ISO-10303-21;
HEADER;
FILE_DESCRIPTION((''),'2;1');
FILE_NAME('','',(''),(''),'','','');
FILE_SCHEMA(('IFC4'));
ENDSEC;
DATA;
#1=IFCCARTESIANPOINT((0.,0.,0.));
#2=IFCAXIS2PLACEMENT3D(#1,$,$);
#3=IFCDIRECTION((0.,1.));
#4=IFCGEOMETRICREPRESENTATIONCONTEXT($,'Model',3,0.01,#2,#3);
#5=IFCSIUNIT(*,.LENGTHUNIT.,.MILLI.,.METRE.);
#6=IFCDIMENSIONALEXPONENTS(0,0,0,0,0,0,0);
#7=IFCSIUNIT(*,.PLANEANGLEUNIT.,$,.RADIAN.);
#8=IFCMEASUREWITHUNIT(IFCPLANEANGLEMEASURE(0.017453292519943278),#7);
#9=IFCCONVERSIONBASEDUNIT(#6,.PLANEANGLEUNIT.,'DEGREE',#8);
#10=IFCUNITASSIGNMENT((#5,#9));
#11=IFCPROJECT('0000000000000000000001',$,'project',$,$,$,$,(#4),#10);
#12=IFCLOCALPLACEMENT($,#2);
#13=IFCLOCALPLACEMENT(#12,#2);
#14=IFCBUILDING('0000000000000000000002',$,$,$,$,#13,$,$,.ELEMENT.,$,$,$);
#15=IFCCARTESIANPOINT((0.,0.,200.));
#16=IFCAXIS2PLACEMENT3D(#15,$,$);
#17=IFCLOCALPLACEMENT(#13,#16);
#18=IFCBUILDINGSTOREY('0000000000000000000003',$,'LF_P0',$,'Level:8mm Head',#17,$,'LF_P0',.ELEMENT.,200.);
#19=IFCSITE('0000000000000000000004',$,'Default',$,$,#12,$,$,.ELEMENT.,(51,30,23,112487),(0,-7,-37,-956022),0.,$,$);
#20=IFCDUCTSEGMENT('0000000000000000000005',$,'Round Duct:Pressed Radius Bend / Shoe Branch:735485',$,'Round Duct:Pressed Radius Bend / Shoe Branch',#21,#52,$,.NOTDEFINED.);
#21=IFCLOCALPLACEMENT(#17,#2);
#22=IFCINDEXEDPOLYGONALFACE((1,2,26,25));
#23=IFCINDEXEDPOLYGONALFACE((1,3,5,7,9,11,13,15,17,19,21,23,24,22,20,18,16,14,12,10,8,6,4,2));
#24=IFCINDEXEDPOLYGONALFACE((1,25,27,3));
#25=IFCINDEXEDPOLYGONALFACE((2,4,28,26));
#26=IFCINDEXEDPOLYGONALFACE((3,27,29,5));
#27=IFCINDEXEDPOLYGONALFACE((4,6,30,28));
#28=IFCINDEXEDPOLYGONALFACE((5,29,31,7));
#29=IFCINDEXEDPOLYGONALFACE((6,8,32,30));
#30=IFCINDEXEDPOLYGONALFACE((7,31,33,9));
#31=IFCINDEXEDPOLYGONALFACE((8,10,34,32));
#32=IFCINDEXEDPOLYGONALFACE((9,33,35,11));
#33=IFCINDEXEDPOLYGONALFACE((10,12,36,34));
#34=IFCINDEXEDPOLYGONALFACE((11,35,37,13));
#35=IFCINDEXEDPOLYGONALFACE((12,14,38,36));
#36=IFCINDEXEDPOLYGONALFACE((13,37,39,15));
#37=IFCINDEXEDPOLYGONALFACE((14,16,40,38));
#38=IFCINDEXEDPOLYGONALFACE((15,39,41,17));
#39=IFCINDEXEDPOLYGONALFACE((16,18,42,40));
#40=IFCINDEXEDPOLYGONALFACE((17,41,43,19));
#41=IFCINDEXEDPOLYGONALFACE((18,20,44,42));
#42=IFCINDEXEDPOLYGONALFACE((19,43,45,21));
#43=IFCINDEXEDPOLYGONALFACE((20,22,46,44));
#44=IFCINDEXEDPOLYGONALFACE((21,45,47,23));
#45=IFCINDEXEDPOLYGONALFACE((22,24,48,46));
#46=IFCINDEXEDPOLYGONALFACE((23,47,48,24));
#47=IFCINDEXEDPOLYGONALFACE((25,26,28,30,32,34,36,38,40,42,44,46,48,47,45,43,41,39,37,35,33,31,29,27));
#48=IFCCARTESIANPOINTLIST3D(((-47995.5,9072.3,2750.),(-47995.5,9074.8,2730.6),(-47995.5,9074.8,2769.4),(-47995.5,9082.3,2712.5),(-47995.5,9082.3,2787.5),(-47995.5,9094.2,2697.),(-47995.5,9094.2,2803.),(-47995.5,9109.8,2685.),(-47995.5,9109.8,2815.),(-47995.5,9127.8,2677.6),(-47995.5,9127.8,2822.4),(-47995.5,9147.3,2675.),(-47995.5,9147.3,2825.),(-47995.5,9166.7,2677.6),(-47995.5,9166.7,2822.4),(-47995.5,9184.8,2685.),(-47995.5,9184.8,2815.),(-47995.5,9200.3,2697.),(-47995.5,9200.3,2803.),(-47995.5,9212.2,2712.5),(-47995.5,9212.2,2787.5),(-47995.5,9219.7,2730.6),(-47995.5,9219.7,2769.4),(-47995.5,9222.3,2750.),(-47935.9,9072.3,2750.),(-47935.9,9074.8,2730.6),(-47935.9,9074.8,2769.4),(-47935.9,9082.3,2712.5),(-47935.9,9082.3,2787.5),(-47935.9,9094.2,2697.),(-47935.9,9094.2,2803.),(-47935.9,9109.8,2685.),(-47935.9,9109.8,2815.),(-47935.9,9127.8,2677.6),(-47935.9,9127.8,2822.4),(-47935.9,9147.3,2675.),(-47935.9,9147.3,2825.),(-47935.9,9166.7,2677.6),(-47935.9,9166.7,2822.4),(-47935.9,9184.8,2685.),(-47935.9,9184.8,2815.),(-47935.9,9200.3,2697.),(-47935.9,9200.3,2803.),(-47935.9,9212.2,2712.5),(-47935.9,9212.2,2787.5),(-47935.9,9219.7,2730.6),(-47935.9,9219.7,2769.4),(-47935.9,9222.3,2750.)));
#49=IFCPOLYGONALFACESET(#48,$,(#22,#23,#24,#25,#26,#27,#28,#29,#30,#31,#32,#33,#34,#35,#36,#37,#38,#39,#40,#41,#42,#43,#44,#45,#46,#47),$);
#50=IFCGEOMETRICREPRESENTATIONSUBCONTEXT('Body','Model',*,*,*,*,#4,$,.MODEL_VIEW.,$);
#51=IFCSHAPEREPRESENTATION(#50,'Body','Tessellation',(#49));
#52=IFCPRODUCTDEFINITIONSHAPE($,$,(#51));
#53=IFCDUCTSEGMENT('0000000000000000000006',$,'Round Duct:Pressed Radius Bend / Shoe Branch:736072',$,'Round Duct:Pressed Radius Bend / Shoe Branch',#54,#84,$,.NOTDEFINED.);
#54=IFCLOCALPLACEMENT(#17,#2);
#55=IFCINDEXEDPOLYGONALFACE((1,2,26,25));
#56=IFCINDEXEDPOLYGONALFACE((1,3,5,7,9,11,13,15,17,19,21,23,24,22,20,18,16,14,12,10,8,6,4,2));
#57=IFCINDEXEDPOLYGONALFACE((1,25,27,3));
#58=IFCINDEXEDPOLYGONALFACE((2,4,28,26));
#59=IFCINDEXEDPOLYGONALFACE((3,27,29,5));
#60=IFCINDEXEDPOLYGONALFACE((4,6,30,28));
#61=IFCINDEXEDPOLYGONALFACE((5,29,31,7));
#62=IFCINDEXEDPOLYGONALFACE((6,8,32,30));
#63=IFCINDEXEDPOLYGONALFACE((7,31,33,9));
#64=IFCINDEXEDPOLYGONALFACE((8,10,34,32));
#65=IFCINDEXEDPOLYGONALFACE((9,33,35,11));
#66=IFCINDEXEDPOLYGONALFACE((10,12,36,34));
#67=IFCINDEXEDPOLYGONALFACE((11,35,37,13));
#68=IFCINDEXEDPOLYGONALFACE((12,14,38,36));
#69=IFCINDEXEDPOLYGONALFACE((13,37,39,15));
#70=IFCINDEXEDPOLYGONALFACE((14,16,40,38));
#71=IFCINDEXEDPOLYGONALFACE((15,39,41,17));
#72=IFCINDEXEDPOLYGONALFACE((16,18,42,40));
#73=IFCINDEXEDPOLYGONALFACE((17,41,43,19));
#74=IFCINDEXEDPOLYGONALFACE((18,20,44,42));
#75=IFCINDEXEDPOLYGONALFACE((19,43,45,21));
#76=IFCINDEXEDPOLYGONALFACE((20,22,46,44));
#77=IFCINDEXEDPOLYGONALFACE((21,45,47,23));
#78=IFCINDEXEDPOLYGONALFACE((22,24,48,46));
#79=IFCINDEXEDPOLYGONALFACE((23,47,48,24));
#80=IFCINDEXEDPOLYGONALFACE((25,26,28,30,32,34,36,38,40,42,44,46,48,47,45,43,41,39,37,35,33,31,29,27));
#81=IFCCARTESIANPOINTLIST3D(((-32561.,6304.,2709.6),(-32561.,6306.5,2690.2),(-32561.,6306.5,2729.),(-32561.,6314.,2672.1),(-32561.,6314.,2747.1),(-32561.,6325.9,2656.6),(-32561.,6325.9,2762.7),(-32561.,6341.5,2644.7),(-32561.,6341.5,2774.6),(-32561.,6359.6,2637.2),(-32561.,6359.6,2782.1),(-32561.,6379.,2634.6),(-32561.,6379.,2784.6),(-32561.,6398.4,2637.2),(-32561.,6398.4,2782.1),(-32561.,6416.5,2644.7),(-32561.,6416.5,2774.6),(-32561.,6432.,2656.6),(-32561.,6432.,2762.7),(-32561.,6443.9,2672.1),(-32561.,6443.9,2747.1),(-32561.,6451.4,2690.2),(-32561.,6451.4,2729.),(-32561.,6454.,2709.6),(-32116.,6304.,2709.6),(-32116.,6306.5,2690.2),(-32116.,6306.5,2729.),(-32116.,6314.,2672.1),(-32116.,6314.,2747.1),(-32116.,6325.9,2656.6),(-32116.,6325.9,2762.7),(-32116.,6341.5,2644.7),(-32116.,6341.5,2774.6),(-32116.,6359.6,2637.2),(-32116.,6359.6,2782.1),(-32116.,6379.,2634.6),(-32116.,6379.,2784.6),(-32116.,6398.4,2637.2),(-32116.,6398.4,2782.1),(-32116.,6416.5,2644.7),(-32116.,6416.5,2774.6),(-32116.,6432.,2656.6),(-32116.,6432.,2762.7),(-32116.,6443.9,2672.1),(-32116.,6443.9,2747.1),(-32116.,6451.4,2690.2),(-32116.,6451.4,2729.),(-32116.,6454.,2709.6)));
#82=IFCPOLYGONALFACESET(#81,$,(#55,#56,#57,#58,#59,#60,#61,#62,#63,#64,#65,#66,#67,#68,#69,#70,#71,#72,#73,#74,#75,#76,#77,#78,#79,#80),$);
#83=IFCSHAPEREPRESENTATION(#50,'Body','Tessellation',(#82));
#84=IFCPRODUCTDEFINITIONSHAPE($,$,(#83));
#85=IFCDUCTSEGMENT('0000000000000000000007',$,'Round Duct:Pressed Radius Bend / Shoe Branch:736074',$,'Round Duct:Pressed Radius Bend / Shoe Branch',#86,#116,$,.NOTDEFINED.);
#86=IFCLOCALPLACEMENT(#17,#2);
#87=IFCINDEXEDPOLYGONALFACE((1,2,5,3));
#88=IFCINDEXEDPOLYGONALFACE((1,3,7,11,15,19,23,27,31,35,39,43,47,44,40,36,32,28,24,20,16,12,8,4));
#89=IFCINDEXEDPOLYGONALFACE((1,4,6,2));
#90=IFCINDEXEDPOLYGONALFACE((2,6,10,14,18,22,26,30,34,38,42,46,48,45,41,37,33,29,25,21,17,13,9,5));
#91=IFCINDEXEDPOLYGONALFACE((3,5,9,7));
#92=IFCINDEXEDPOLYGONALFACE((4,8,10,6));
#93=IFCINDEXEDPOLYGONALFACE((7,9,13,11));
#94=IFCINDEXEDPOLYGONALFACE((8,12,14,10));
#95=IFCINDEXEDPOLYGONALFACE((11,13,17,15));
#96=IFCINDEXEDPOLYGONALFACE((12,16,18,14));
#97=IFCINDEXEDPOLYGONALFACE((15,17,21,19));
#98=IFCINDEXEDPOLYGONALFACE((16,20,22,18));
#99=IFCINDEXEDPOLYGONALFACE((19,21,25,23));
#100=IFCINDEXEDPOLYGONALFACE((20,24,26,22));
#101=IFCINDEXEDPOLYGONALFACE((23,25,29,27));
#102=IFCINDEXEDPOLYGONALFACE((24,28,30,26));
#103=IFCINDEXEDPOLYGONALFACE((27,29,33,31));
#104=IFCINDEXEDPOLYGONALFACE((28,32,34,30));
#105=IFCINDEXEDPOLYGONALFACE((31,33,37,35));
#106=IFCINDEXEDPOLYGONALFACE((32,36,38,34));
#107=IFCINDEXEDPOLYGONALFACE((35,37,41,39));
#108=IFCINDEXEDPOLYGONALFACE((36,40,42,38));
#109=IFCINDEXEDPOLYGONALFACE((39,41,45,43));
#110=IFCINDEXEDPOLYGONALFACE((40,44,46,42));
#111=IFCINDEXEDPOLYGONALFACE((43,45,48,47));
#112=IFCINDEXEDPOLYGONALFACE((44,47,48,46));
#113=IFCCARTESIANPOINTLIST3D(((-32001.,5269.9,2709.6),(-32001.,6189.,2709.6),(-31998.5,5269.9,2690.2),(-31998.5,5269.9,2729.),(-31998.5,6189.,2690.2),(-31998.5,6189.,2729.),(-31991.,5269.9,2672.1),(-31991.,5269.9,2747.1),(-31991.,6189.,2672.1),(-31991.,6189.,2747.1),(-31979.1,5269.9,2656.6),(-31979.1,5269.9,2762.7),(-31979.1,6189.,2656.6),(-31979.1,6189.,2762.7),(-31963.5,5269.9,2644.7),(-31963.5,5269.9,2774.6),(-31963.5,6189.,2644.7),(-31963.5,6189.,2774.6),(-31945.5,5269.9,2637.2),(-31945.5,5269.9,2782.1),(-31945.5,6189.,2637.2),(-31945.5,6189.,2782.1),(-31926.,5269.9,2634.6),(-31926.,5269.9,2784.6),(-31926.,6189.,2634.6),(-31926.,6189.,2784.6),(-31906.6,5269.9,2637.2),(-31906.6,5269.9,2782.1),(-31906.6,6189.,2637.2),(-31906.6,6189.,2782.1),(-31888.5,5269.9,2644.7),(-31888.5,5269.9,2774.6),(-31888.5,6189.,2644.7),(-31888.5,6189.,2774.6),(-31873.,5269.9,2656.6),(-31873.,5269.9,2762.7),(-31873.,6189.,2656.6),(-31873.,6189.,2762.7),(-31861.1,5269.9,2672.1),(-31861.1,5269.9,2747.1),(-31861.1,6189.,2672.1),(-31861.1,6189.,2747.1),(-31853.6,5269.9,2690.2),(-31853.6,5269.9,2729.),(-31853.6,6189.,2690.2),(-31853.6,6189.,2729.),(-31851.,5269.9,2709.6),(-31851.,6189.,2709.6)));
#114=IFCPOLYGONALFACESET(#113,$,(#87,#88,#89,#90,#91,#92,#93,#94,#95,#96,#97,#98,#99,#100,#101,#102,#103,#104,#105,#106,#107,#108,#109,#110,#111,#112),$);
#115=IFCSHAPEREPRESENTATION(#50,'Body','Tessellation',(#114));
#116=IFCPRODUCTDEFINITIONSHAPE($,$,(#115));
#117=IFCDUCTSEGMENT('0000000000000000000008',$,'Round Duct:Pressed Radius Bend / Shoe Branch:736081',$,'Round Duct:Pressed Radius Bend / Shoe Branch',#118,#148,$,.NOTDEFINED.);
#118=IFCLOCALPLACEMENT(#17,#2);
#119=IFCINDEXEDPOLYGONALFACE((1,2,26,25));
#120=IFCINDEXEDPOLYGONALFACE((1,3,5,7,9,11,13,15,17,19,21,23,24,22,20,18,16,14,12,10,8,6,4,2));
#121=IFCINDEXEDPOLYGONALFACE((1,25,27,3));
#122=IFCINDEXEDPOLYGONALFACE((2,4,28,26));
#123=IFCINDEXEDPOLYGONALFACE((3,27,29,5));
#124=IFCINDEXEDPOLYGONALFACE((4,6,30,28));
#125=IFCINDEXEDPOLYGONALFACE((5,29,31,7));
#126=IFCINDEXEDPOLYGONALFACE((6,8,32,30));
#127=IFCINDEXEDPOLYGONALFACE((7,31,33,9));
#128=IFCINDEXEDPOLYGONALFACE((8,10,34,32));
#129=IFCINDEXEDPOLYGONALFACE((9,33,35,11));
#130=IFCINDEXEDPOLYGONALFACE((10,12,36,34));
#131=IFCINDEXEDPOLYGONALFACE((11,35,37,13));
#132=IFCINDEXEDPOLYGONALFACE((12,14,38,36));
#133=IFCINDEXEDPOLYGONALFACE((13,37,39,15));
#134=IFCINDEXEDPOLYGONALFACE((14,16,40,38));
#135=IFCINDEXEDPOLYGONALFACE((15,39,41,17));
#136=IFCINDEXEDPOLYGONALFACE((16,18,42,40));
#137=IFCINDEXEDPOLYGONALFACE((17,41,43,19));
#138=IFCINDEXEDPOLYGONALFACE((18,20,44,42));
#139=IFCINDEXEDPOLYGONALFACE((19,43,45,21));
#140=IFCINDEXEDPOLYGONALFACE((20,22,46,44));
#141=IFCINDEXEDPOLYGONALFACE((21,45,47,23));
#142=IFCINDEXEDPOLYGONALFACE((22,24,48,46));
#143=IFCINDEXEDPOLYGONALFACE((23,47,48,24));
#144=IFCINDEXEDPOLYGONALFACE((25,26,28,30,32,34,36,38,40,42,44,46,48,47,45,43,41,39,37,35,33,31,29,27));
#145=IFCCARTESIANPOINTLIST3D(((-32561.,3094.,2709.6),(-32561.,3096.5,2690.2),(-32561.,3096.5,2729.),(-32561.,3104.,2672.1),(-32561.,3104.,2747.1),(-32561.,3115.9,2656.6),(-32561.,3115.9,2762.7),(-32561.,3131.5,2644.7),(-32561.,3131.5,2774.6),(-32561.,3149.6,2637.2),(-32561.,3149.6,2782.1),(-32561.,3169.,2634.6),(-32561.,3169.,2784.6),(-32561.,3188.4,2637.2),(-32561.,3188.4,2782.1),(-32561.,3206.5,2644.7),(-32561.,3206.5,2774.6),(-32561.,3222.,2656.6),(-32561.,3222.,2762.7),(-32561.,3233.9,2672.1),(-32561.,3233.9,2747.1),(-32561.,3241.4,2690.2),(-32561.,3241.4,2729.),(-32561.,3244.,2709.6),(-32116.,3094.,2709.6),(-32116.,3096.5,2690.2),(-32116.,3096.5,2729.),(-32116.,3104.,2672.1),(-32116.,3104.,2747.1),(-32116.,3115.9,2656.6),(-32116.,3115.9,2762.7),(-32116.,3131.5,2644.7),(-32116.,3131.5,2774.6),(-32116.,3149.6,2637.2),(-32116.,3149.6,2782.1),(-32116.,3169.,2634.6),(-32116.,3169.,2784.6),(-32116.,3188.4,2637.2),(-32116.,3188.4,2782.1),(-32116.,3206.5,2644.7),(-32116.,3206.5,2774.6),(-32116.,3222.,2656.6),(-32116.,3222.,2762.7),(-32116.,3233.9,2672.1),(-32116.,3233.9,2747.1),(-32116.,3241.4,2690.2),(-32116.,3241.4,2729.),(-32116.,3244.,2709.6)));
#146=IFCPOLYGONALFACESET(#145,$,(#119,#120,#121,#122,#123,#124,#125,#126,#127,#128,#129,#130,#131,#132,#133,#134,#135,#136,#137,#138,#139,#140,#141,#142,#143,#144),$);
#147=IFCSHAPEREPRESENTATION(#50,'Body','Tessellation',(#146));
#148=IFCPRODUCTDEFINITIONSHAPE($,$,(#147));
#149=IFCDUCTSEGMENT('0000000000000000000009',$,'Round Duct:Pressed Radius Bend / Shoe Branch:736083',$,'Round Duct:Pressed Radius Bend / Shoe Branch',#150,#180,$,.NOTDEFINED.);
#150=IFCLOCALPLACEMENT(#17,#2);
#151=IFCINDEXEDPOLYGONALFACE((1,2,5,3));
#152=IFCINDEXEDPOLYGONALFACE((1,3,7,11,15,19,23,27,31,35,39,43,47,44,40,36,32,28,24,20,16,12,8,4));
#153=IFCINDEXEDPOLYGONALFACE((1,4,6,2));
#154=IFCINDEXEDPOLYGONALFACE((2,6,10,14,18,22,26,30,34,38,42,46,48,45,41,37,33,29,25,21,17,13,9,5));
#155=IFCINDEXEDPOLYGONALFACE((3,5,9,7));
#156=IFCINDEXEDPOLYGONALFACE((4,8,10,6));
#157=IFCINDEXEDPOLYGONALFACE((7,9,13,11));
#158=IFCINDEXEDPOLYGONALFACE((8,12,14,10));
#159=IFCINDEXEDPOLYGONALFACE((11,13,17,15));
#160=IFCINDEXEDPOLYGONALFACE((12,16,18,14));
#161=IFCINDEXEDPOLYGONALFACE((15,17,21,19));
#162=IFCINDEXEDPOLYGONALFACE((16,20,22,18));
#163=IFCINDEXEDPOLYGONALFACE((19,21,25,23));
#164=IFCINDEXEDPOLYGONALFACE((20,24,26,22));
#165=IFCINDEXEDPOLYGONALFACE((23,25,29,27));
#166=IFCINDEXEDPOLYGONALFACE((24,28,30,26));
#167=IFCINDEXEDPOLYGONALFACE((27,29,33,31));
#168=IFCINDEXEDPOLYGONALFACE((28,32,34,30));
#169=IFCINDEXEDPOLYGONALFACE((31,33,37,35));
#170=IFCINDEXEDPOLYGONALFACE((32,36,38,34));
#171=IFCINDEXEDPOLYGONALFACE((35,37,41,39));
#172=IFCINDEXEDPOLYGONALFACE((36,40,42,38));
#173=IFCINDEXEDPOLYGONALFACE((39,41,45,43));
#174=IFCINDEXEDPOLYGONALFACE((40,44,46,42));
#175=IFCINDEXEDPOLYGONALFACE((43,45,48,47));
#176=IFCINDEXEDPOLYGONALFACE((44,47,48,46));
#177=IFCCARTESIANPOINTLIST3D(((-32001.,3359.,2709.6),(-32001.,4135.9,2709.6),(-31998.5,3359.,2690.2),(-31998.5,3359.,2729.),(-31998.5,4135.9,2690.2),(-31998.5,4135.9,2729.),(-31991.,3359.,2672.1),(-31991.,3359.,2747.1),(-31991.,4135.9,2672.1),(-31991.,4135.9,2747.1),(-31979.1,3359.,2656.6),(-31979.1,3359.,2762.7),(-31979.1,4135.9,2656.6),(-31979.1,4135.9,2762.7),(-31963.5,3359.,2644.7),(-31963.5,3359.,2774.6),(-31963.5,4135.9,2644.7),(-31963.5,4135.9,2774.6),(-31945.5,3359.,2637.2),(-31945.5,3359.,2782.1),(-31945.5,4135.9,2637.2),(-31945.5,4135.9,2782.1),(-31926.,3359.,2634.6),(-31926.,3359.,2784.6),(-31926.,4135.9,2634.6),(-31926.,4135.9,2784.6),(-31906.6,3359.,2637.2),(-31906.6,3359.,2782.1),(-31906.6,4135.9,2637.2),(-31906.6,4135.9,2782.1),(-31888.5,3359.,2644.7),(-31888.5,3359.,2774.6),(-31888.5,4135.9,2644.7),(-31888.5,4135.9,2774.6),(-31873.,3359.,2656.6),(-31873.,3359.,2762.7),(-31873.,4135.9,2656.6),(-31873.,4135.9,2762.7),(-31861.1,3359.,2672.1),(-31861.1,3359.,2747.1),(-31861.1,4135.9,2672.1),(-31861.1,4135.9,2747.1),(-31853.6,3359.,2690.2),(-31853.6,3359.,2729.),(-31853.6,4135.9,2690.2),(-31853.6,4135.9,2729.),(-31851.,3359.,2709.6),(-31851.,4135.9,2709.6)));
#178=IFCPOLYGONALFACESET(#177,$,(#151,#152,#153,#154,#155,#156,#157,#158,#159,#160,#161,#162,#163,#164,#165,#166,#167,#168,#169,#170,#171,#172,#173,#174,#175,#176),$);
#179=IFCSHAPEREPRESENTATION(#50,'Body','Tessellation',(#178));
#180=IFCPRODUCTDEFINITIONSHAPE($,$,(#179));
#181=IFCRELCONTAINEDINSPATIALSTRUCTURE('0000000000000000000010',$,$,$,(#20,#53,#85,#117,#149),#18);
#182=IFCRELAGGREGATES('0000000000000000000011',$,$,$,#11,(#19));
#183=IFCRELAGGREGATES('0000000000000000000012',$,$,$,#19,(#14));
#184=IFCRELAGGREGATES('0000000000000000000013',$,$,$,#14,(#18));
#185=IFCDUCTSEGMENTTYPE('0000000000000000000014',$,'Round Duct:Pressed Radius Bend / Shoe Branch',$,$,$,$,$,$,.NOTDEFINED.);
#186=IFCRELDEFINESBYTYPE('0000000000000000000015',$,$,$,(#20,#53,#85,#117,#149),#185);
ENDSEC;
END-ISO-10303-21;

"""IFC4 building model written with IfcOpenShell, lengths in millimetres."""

from ifc_helpers import new_model, entity, si_unit, converted_unit, direction, frame, origin, place, context, subcontext, project, spatial, arc, indexed_curve, outline, extrude, type_object, element, save


model = new_model("IFC4")

# Units and contexts
model_context = context("Model", 3, precision=0.01, world=origin(), true_north=direction((0.0, 1.0)))
body_context = subcontext(model_context, "Body", "Model", "MODEL_VIEW")
ifc_project = project(units=[si_unit("LENGTHUNIT", "METRE", prefix="MILLI"), converted_unit("PLANEANGLEUNIT", "DEGREE", entity("IfcPlaneAngleMeasure", 0.017453292519943278), si_unit("PLANEANGLEUNIT", "RADIAN"), dimensions=[0, 0, 0, 0, 0, 0, 0])], contexts=[model_context])

# Site, building, storey
site_placement = place(None, origin())
site = spatial("IfcSite", under=ifc_project, at=site_placement, Name="Default", CompositionType="ELEMENT", RefLatitude=(51, 30, 23, 112487), RefLongitude=(0, -7, -37, -956022), RefElevation=0.0)
building_placement = place(site_placement, origin())
building = spatial("IfcBuilding", under=site, at=building_placement, CompositionType="ELEMENT")
storey_placement = place(building_placement, frame((0.0, 0.0, 200.0)))
storey = spatial("IfcBuildingStorey", under=building, at=storey_placement, Name="LF_P0", ObjectType="Level:8mm Head", LongName="LF_P0", CompositionType="ELEMENT", Elevation=200.0)

# Duct segments
duct_segment_type_1 = type_object("IfcDuctSegmentType", Name="Round Duct:Pressed Radius Bend / Shoe Branch", PredefinedType="NOTDEFINED")
duct_segment_1_placement = place(storey_placement, origin())
element("IfcDuctSegment", 1, at=duct_segment_1_placement, inside=storey, type_object=duct_segment_type_1, Name="Round Duct:Pressed Radius Bend / Shoe Branch:735485", ObjectType="Round Duct:Pressed Radius Bend / Shoe Branch", PredefinedType="NOTDEFINED", context=body_context, shape_type="SweptSolid", body=[
    extrude(outline(indexed_curve([(75.0, 0.0), (53.0, 53.0), (0.0, 75.0), (-53.0, 53.0), (-75.0, 0.0), (-53.0, -53.0), (0.0, -75.0), (53.0, -53.0)], segments=[arc(1, 2, 3), arc(3, 4, 5), arc(5, 6, 7), arc(7, 8, 1)], self_intersect=False)), frame((-47995.5, 9147.3, 2750.0), z_axis=(1.0, 0.0, 0.0), x_axis=(0.0, -1.0, 0.0)), (0.0, 0.0, 1.0), 59.6),
])
duct_segment_2_placement = place(storey_placement, origin())
element("IfcDuctSegment", 2, at=duct_segment_2_placement, inside=storey, type_object=duct_segment_type_1, Name="Round Duct:Pressed Radius Bend / Shoe Branch:736072", ObjectType="Round Duct:Pressed Radius Bend / Shoe Branch", PredefinedType="NOTDEFINED", context=body_context, shape_type="SweptSolid", body=[
    extrude(outline(indexed_curve([(75.0, 0.0), (53.0, 53.0), (0.0, 75.0), (-53.0, 53.0), (-75.0, 0.0), (-53.0, -53.0), (0.0, -75.0), (53.0, -53.0)], segments=[arc(1, 2, 3), arc(3, 4, 5), arc(5, 6, 7), arc(7, 8, 1)], self_intersect=False)), frame((-32561.0, 6379.0, 2709.6), z_axis=(1.0, 0.0, 0.0), x_axis=(0.0, -1.0, 0.0)), (0.0, 0.0, 1.0), 445.0),
])
duct_segment_3_placement = place(storey_placement, origin())
element("IfcDuctSegment", 3, at=duct_segment_3_placement, inside=storey, type_object=duct_segment_type_1, Name="Round Duct:Pressed Radius Bend / Shoe Branch:736074", ObjectType="Round Duct:Pressed Radius Bend / Shoe Branch", PredefinedType="NOTDEFINED", context=body_context, shape_type="SweptSolid", body=[
    extrude(outline(indexed_curve([(75.0, 0.0), (53.0, 53.0), (0.0, 75.0), (-53.0, 53.0), (-75.0, 0.0), (-53.0, -53.0), (0.0, -75.0), (53.0, -53.0)], segments=[arc(1, 2, 3), arc(3, 4, 5), arc(5, 6, 7), arc(7, 8, 1)], self_intersect=False)), frame((-31926.0, 5269.9, 2709.6), z_axis=(0.0, 1.0, 0.0), x_axis=(1.0, 0.0, 0.0)), (0.0, 0.0, 1.0), 919.0),
])
duct_segment_4_placement = place(storey_placement, origin())
element("IfcDuctSegment", 4, at=duct_segment_4_placement, inside=storey, type_object=duct_segment_type_1, Name="Round Duct:Pressed Radius Bend / Shoe Branch:736081", ObjectType="Round Duct:Pressed Radius Bend / Shoe Branch", PredefinedType="NOTDEFINED", context=body_context, shape_type="SweptSolid", body=[
    extrude(outline(indexed_curve([(75.0, 0.0), (53.0, 53.0), (0.0, 75.0), (-53.0, 53.0), (-75.0, 0.0), (-53.0, -53.0), (0.0, -75.0), (53.0, -53.0)], segments=[arc(1, 2, 3), arc(3, 4, 5), arc(5, 6, 7), arc(7, 8, 1)], self_intersect=False)), frame((-32561.0, 3169.0, 2709.6), z_axis=(1.0, 0.0, 0.0), x_axis=(0.0, -1.0, 0.0)), (0.0, 0.0, 1.0), 445.0),
])
duct_segment_5_placement = place(storey_placement, origin())
element("IfcDuctSegment", 5, at=duct_segment_5_placement, inside=storey, type_object=duct_segment_type_1, Name="Round Duct:Pressed Radius Bend / Shoe Branch:736083", ObjectType="Round Duct:Pressed Radius Bend / Shoe Branch", PredefinedType="NOTDEFINED", context=body_context, shape_type="SweptSolid", body=[
    extrude(outline(indexed_curve([(75.0, 0.0), (53.0, 53.0), (0.0, 75.0), (-53.0, 53.0), (-75.0, 0.0), (-53.0, -53.0), (0.0, -75.0), (53.0, -53.0)], segments=[arc(1, 2, 3), arc(3, 4, 5), arc(5, 6, 7), arc(7, 8, 1)], self_intersect=False)), frame((-31926.0, 3359.0, 2709.6), z_axis=(0.0, 1.0, 0.0), x_axis=(-1.0, 0.0, 0.0)), (0.0, 0.0, 1.0), 777.0),
])

save(model, "model.ifc")
